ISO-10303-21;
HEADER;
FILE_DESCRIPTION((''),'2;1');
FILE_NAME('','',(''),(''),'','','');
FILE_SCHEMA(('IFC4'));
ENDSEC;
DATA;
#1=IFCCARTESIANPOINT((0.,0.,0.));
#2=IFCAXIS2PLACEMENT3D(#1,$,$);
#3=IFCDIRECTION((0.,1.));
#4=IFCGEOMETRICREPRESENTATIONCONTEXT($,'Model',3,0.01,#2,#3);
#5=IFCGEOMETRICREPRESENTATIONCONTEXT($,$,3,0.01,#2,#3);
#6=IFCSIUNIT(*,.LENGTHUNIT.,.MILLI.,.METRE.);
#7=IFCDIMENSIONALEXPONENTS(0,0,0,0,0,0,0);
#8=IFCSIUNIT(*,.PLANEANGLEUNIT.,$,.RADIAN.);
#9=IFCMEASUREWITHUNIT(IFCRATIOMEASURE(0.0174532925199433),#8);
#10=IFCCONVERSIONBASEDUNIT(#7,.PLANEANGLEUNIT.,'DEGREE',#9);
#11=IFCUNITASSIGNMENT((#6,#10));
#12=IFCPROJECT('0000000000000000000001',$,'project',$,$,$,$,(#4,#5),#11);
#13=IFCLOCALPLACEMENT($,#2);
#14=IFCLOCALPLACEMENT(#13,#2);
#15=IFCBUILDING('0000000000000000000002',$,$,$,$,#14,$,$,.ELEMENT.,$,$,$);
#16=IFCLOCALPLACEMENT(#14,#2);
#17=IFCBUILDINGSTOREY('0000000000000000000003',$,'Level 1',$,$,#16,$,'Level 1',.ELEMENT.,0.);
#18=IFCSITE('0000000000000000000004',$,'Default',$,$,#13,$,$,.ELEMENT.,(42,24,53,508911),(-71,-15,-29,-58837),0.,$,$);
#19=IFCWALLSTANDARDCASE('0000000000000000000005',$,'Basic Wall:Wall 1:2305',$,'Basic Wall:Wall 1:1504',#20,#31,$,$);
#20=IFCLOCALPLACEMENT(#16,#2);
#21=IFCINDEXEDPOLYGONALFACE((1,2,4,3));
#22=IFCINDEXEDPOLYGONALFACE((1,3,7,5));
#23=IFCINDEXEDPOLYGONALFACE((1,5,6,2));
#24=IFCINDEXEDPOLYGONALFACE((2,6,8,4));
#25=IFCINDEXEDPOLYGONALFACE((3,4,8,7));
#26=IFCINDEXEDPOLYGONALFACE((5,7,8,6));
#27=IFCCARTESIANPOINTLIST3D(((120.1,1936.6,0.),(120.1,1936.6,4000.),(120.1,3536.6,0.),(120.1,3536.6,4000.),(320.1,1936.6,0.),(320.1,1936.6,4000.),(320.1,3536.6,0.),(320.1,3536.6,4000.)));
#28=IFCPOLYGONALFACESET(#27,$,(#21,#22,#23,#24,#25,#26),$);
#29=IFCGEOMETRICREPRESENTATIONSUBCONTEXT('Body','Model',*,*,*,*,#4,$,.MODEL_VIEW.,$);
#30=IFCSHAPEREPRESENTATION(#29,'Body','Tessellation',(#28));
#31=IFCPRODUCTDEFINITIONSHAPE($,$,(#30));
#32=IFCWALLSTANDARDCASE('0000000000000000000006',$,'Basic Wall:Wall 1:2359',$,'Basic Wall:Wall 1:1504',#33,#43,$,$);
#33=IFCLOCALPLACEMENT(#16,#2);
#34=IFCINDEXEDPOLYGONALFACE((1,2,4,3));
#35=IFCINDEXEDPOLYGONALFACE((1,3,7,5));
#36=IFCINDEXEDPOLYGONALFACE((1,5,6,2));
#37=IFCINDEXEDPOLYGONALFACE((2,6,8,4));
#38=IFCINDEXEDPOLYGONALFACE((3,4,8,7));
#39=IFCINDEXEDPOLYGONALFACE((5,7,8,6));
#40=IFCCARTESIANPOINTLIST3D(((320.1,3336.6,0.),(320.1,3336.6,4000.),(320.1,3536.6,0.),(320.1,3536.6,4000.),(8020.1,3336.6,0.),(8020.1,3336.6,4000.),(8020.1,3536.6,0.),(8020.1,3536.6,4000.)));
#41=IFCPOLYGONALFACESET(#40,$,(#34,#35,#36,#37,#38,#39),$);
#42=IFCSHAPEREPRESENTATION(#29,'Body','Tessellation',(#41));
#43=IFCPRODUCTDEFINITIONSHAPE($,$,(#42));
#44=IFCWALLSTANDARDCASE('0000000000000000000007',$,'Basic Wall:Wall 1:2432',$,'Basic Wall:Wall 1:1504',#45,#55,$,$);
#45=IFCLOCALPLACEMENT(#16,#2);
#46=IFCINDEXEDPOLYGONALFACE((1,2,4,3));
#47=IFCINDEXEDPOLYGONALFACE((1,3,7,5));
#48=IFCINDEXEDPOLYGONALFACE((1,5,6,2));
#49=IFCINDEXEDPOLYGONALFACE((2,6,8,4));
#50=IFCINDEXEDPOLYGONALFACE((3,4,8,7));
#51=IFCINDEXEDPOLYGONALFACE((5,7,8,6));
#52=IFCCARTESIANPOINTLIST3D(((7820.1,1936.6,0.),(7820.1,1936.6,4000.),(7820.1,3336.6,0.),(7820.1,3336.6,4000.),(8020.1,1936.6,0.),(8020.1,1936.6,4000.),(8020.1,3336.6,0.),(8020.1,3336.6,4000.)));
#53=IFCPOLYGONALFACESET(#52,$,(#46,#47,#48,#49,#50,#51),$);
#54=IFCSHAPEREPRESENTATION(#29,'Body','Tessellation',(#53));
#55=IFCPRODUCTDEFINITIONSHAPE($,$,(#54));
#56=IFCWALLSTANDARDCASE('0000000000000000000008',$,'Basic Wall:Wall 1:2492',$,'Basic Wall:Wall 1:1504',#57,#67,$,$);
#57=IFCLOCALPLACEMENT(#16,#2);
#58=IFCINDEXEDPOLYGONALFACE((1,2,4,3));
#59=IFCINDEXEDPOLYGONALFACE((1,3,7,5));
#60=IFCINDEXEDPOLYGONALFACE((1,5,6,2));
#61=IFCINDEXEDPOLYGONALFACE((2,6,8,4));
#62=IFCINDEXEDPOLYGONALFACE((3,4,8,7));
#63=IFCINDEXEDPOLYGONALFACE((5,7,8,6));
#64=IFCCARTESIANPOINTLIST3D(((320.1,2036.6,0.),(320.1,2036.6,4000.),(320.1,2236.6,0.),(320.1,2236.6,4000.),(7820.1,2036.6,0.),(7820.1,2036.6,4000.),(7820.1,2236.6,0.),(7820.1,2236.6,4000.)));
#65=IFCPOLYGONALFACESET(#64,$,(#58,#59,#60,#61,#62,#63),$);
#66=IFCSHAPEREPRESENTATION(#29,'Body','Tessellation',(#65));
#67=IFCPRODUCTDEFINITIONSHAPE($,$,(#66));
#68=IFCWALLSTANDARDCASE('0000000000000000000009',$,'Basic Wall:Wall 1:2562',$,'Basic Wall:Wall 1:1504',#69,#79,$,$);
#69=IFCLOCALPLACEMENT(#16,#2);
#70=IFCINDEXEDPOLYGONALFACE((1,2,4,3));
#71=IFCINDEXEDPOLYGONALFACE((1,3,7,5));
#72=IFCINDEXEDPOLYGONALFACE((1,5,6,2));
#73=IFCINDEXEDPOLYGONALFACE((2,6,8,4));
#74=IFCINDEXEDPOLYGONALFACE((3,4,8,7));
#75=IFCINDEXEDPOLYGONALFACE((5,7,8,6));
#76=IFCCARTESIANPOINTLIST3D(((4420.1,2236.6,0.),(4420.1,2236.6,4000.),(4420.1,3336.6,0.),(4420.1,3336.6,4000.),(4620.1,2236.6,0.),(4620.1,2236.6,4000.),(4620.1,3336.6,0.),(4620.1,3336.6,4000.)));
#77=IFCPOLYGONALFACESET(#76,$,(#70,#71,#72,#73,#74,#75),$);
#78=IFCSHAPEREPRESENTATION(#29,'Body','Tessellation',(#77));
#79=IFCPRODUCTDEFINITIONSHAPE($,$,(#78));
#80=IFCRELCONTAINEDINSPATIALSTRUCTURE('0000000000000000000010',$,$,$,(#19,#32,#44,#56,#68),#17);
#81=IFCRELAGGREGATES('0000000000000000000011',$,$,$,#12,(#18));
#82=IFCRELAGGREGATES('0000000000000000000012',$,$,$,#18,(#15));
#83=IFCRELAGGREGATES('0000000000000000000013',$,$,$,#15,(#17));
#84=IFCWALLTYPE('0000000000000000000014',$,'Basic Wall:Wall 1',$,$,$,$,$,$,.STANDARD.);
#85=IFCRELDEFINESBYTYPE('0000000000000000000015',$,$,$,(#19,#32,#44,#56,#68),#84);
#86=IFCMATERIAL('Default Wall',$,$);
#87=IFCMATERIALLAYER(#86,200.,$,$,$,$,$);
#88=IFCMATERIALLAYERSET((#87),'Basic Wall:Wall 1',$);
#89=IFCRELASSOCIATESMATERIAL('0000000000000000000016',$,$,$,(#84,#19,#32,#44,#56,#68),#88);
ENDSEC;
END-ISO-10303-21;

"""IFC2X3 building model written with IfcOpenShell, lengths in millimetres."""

from ifc_helpers import new_model, entity, si_unit, converted_unit, direction, frame, frame_2d, origin, place, context, subcontext, project, spatial, rectangle, extrude, material, layer, layer_set, layer_usage, type_object, element, save


model = new_model("IFC2X3")

# Units and contexts
model_context = context("Model", 3, precision=0.01, world=origin(), true_north=direction((0.0, 1.0)))
context_of_model = context(None, 3, precision=0.01, world=origin(), true_north=direction((0.0, 1.0)))
body_context = subcontext(model_context, "Body", "Model", "MODEL_VIEW")
ifc_project = project(units=[si_unit("LENGTHUNIT", "METRE", prefix="MILLI"), converted_unit("PLANEANGLEUNIT", "DEGREE", entity("IfcRatioMeasure", 0.0174532925199433), si_unit("PLANEANGLEUNIT", "RADIAN"), dimensions=[0, 0, 0, 0, 0, 0, 0])], contexts=[model_context, context_of_model])

# Site, building, storey
site_placement = place(None, origin())
site = spatial("IfcSite", under=ifc_project, at=site_placement, Name="Default", CompositionType="ELEMENT", RefLatitude=(42, 24, 53, 508911), RefLongitude=(-71, -15, -29, -58837), RefElevation=0.0)
building_placement = place(site_placement, origin())
building = spatial("IfcBuilding", under=site, at=building_placement, CompositionType="ELEMENT")
storey_placement = place(building_placement, origin())
storey = spatial("IfcBuildingStorey", under=building, at=storey_placement, Name="Level 1", LongName="Level 1", CompositionType="ELEMENT", Elevation=0.0)

# Walls
ifc_material = material(Name="Default Wall")
ifc_layer = layer(ifc_material, 200.0)
ifc_layer_set = layer_set([ifc_layer], Name="Basic Wall:Wall 1")
ifc_layer_usage_1 = layer_usage(ifc_layer_set, "AXIS2", "NEGATIVE", 100.0)
wall_type = type_object("IfcWallType", Name="Basic Wall:Wall 1", PredefinedType="STANDARD", material=ifc_layer_set)
wall_1_placement = place(storey_placement, frame((220.1, 1936.6, 0.0), z_axis=(0.0, 0.0, 1.0), x_axis=(0.0, 1.0, 0.0)))
element("IfcWallStandardCase", 1, at=wall_1_placement, inside=storey, type_object=wall_type, material=ifc_layer_usage_1, Name="Basic Wall:Wall 1:2305", ObjectType="Basic Wall:Wall 1:1504", context=body_context, shape_type="SweptSolid", body=[
    extrude(rectangle(XDim=1600.0, YDim=200.0, at=frame_2d((800.0, 0.0), x_axis=(-1.0, 0.0))), origin(), (0.0, 0.0, 1.0), 4000.0),
])
ifc_layer_usage_2 = layer_usage(ifc_layer_set, "AXIS2", "NEGATIVE", 100.0)
wall_2_placement = place(storey_placement, frame((320.1, 3436.6, 0.0)))
element("IfcWallStandardCase", 2, at=wall_2_placement, inside=storey, type_object=wall_type, material=ifc_layer_usage_2, Name="Basic Wall:Wall 1:2359", ObjectType="Basic Wall:Wall 1:1504", context=body_context, shape_type="SweptSolid", body=[
    extrude(rectangle(XDim=7700.0, YDim=200.0, at=frame_2d((3850.0, 0.0), x_axis=(-1.0, 0.0))), origin(), (0.0, 0.0, 1.0), 4000.0),
])
ifc_layer_usage_3 = layer_usage(ifc_layer_set, "AXIS2", "NEGATIVE", 100.0)
wall_3_placement = place(storey_placement, frame((7920.1, 3336.6, 0.0), z_axis=(0.0, 0.0, 1.0), x_axis=(0.0, -1.0, 0.0)))
element("IfcWallStandardCase", 3, at=wall_3_placement, inside=storey, type_object=wall_type, material=ifc_layer_usage_3, Name="Basic Wall:Wall 1:2432", ObjectType="Basic Wall:Wall 1:1504", context=body_context, shape_type="SweptSolid", body=[
    extrude(rectangle(XDim=1400.0, YDim=200.0, at=frame_2d((700.0, 0.0), x_axis=(-1.0, 0.0))), origin(), (0.0, 0.0, 1.0), 4000.0),
])
ifc_layer_usage_4 = layer_usage(ifc_layer_set, "AXIS2", "NEGATIVE", 100.0)
wall_4_placement = place(storey_placement, frame((7820.1, 2136.6, 0.0), z_axis=(0.0, 0.0, 1.0), x_axis=(-1.0, 0.0, 0.0)))
element("IfcWallStandardCase", 4, at=wall_4_placement, inside=storey, type_object=wall_type, material=ifc_layer_usage_4, Name="Basic Wall:Wall 1:2492", ObjectType="Basic Wall:Wall 1:1504", context=body_context, shape_type="SweptSolid", body=[
    extrude(rectangle(XDim=7500.0, YDim=200.0, at=frame_2d((3750.0, 0.0), x_axis=(-1.0, 0.0))), origin(), (0.0, 0.0, 1.0), 4000.0),
])
ifc_layer_usage_5 = layer_usage(ifc_layer_set, "AXIS2", "NEGATIVE", 100.0)
wall_5_placement = place(storey_placement, frame((4520.1, 2236.6, 0.0), z_axis=(0.0, 0.0, 1.0), x_axis=(0.0, 1.0, 0.0)))
element("IfcWallStandardCase", 5, at=wall_5_placement, inside=storey, type_object=wall_type, material=ifc_layer_usage_5, Name="Basic Wall:Wall 1:2562", ObjectType="Basic Wall:Wall 1:1504", context=body_context, shape_type="SweptSolid", body=[
    extrude(rectangle(XDim=1100.0, YDim=200.0, at=frame_2d((550.0, 0.0), x_axis=(-1.0, 0.0))), origin(), (0.0, 0.0, 1.0), 4000.0),
])

save(model, "model.ifc")
